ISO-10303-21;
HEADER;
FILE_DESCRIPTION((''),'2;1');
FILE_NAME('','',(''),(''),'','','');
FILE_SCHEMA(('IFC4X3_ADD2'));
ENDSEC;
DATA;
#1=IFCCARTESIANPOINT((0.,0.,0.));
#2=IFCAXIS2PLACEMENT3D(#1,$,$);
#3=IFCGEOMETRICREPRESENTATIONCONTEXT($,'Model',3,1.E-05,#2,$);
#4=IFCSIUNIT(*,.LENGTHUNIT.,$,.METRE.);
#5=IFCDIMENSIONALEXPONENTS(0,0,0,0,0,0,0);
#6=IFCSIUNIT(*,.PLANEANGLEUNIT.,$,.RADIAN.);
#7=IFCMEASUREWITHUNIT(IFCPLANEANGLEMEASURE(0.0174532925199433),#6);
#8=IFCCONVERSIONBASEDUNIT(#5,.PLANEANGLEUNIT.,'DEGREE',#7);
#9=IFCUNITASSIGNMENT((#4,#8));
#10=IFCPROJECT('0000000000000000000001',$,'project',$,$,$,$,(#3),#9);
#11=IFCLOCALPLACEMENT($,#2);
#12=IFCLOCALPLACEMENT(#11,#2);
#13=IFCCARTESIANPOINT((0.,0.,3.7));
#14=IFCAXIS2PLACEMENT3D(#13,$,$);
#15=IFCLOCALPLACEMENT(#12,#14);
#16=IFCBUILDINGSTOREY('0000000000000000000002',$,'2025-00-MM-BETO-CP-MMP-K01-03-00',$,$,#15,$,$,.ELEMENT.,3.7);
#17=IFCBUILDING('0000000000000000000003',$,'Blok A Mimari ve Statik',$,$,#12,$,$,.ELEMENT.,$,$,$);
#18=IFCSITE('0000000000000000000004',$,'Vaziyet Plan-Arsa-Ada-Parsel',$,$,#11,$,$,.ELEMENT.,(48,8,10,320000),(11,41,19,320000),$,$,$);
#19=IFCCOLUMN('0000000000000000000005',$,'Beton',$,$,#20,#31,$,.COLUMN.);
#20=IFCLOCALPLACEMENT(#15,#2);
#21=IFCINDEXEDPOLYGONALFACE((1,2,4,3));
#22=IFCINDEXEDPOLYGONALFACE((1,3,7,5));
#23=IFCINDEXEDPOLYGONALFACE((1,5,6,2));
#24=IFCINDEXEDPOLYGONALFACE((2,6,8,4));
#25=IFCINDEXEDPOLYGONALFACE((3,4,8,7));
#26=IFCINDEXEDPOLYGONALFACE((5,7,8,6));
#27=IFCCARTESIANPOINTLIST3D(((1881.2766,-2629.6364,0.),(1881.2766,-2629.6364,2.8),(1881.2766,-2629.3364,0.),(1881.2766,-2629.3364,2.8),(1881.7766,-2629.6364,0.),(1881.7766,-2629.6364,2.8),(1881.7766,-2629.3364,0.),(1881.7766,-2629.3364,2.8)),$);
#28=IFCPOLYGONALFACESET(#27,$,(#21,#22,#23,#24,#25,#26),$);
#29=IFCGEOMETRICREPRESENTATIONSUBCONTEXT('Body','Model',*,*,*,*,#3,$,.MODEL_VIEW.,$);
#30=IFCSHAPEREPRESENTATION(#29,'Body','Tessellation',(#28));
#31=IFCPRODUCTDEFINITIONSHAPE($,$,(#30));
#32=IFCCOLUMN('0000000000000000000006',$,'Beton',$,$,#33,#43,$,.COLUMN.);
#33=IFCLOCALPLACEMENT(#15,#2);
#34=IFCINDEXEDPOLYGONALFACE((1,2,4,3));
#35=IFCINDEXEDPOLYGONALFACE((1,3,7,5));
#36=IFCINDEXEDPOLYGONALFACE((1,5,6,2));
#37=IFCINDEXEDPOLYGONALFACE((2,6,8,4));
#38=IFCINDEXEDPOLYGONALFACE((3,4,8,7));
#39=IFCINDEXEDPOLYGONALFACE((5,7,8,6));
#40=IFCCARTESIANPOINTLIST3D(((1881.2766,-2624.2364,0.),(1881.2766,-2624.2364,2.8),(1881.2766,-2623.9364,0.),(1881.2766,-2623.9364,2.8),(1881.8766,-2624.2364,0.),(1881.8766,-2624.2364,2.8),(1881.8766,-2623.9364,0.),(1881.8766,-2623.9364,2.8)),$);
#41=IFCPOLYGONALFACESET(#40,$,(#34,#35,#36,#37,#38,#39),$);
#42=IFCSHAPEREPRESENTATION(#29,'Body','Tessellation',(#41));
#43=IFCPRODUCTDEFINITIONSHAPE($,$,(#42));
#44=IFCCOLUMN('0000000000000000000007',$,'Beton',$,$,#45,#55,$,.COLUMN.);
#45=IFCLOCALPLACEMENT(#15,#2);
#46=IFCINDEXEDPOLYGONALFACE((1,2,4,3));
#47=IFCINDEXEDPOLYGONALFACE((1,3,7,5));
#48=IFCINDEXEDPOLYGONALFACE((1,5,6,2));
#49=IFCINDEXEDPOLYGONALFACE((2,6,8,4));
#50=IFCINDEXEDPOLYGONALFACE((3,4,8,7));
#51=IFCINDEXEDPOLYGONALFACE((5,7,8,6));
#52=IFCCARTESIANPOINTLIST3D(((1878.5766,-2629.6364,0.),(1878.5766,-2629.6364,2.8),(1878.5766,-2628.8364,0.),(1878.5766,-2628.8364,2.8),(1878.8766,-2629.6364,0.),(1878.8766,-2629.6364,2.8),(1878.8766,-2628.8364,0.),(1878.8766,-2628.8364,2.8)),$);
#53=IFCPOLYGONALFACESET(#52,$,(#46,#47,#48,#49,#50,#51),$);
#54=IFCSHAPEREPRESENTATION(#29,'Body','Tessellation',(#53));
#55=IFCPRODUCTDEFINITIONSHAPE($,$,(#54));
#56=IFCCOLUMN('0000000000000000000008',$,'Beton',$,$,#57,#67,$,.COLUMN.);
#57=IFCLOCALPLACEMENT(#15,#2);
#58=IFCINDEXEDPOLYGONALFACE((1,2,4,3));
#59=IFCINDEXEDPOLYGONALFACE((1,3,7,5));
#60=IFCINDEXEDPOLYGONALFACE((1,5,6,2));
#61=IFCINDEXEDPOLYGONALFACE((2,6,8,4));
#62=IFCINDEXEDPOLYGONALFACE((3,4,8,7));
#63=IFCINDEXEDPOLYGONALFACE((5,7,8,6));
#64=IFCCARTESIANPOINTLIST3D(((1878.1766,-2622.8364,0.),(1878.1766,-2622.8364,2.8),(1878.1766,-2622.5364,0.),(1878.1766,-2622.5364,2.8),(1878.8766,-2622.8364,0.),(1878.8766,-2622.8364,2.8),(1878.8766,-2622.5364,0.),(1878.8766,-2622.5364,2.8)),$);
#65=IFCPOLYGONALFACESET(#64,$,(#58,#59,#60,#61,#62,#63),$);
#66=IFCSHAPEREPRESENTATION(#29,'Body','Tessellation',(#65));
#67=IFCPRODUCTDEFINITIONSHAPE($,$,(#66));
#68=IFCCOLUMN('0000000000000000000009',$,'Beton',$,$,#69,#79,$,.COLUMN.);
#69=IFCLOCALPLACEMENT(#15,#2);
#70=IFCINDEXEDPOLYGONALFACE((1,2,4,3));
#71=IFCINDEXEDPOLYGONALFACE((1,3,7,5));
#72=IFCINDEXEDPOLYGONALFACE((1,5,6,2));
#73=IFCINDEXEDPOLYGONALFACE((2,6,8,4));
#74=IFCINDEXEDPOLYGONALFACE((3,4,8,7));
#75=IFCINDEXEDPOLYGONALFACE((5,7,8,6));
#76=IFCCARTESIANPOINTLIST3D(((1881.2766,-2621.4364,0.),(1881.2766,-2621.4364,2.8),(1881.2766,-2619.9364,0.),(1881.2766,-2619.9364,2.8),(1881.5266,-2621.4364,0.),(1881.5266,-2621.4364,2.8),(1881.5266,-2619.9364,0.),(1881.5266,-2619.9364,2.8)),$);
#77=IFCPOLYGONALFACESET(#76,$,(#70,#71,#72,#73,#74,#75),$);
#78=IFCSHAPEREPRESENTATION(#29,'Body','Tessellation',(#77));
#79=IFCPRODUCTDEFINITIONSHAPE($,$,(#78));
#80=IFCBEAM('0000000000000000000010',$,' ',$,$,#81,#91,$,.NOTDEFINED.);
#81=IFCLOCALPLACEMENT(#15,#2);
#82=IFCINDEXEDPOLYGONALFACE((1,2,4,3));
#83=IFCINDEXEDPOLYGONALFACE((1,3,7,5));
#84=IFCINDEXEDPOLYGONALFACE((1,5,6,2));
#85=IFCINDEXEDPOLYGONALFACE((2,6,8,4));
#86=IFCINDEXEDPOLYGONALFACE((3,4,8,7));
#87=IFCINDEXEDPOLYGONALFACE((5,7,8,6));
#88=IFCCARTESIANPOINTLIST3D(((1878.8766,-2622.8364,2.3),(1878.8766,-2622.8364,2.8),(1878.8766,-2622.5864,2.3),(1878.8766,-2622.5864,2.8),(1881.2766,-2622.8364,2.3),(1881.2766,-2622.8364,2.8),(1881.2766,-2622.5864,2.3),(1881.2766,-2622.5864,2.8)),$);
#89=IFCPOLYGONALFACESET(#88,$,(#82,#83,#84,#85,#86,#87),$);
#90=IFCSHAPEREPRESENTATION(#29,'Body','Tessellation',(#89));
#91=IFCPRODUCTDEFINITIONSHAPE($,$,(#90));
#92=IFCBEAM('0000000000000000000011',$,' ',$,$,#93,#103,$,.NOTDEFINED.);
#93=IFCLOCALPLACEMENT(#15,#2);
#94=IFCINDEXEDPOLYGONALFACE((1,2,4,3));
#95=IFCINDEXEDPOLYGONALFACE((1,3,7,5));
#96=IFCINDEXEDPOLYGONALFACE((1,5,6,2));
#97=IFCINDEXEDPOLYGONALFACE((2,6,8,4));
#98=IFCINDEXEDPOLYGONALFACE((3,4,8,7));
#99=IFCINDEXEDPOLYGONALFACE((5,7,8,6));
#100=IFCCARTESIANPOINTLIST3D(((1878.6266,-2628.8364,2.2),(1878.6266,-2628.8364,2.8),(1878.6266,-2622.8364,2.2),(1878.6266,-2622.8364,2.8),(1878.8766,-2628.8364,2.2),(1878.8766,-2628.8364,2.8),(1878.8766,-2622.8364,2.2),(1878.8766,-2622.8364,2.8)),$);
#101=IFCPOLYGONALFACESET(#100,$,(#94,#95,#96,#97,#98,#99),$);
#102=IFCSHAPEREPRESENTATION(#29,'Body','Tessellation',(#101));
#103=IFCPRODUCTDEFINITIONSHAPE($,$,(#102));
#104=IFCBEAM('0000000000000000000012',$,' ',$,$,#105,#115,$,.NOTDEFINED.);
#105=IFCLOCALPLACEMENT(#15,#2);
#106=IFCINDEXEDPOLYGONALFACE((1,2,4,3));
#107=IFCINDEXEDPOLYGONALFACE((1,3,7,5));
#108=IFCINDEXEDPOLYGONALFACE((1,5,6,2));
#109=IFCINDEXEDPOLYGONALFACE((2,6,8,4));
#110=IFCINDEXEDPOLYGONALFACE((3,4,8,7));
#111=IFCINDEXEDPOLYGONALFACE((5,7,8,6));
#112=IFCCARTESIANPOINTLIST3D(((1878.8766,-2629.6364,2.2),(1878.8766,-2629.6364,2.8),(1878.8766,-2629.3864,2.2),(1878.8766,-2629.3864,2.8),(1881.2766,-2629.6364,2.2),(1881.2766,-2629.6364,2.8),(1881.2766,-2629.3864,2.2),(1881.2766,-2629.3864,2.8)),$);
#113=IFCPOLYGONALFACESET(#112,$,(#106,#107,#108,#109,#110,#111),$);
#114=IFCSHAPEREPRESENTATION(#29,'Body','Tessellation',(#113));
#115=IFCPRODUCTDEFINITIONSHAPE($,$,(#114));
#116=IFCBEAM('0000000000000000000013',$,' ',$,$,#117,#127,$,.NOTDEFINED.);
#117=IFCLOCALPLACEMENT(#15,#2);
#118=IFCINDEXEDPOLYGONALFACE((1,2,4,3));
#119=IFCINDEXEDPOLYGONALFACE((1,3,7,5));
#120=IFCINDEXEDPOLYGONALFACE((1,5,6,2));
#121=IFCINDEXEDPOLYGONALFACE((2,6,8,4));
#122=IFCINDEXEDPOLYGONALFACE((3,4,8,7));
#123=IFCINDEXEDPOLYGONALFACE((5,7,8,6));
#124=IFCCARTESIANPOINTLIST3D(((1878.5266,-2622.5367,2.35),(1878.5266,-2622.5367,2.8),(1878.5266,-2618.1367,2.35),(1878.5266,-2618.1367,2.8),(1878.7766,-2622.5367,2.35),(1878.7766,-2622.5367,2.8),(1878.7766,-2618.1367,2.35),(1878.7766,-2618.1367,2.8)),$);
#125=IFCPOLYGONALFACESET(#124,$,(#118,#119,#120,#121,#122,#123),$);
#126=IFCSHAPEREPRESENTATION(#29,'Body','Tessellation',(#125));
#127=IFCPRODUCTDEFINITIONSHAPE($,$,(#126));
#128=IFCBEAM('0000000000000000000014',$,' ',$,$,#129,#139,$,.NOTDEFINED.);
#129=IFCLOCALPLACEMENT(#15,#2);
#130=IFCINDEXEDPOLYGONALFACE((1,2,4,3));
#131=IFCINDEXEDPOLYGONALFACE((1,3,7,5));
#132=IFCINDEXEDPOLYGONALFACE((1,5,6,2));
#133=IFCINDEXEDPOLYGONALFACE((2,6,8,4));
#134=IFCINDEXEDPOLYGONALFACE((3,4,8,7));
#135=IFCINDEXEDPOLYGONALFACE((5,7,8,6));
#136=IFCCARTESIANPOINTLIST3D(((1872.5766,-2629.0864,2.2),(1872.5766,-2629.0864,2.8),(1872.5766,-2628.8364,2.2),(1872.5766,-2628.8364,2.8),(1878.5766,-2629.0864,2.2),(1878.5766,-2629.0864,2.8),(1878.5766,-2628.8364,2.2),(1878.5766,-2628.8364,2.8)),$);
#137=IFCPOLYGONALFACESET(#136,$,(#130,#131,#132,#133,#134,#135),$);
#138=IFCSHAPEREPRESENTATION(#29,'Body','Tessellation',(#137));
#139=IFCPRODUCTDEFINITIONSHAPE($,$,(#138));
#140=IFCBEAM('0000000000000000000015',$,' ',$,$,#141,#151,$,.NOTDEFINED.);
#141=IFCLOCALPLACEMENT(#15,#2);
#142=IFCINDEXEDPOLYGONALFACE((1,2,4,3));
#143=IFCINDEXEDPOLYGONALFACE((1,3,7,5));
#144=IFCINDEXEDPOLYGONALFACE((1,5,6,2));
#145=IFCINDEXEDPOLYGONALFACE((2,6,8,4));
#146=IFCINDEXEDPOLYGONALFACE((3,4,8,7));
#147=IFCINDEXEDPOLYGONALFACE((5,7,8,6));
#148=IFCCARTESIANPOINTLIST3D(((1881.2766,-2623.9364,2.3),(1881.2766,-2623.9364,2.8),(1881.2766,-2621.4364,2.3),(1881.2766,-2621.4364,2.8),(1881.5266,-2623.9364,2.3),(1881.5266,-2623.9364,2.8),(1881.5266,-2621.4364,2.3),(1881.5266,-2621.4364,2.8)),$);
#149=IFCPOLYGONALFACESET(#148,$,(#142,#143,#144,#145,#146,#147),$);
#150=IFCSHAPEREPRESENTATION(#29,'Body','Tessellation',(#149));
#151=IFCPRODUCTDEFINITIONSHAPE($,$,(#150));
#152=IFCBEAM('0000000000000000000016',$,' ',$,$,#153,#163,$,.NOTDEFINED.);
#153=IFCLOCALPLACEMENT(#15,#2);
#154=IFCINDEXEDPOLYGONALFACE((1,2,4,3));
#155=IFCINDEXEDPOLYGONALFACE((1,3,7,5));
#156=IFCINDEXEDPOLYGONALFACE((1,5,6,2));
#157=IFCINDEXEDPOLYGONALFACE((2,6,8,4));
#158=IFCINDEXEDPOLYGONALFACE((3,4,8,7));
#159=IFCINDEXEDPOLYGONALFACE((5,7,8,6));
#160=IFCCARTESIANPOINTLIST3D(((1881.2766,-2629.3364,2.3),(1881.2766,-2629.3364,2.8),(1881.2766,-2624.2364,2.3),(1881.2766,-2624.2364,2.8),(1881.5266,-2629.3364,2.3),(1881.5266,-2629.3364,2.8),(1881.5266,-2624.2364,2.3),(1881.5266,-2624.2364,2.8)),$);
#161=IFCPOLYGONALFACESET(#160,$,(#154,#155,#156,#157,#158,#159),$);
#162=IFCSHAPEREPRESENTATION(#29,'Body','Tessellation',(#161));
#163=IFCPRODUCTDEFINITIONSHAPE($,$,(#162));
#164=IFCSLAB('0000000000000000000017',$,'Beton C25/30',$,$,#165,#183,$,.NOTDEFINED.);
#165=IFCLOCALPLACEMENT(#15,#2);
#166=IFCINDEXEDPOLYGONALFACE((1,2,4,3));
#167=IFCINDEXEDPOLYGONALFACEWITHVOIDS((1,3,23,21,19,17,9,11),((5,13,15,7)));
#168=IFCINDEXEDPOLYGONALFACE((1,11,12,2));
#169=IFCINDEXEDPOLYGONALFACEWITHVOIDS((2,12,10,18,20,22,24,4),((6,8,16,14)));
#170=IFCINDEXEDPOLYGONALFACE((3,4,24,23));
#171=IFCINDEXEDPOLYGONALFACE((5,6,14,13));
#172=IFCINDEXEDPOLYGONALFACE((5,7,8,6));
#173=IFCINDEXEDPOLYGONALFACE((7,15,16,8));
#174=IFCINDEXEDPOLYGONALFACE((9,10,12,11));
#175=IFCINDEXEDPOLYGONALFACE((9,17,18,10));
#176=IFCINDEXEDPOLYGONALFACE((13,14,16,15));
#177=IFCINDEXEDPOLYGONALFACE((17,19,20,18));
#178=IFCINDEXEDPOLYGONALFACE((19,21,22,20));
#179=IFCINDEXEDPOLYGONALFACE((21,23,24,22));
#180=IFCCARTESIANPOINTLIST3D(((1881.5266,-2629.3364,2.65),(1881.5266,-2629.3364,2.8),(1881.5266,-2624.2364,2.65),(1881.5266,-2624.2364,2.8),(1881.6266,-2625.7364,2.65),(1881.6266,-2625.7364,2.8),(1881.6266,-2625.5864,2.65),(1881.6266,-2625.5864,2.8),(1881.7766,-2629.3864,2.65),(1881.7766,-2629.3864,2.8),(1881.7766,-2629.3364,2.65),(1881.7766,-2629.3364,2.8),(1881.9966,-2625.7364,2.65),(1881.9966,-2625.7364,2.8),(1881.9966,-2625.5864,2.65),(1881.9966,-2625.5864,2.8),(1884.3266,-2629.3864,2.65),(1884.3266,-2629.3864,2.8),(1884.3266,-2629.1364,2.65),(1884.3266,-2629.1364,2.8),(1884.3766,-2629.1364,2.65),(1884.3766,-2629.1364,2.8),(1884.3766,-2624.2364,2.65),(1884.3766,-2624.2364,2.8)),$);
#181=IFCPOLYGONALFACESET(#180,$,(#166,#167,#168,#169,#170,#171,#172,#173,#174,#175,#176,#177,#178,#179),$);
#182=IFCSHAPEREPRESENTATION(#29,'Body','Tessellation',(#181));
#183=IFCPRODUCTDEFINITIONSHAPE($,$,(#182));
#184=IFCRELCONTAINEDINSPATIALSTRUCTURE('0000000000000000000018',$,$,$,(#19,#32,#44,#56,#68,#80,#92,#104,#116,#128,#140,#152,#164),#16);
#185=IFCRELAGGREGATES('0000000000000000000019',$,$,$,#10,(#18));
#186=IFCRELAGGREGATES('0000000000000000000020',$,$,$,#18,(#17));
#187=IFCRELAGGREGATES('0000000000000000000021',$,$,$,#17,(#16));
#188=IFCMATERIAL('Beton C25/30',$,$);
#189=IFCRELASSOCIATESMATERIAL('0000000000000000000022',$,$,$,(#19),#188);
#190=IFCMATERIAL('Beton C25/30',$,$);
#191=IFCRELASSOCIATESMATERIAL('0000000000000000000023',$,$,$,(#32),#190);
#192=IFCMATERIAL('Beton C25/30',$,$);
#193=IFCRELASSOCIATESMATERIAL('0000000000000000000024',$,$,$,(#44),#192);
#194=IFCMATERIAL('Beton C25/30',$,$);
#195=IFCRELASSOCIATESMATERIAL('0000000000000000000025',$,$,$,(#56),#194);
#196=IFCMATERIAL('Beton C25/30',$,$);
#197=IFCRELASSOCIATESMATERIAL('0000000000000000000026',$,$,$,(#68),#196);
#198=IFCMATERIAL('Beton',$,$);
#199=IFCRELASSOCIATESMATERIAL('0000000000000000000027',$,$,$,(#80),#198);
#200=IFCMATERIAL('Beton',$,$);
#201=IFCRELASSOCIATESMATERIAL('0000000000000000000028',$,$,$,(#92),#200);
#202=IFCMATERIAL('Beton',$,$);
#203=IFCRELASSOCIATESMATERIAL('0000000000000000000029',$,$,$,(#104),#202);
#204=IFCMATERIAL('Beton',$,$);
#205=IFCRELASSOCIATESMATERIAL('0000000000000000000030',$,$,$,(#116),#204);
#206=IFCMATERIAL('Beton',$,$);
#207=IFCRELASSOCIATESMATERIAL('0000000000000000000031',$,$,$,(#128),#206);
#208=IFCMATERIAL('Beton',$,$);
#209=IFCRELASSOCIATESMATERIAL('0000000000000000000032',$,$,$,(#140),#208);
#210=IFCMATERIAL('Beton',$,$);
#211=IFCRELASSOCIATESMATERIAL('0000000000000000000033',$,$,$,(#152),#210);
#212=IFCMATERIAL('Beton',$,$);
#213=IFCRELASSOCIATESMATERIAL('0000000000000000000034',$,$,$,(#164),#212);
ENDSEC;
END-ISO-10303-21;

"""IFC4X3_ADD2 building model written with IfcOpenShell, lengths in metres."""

from ifc_helpers import new_model, entity, si_unit, converted_unit, frame, frame_2d, origin, origin_with_axes, place, context, subcontext, project, spatial, polyline, rectangle, outline, extrude, material, element, save


model = new_model("IFC4X3_ADD2")

# Units and contexts
model_context = context("Model", 3, precision=1e-05, world=origin())
body_context = subcontext(model_context, "Body", "Model", "MODEL_VIEW")
ifc_project = project(units=[si_unit("LENGTHUNIT", "METRE"), converted_unit("PLANEANGLEUNIT", "DEGREE", entity("IfcPlaneAngleMeasure", 0.0174532925199433), si_unit("PLANEANGLEUNIT", "RADIAN"), dimensions=[0, 0, 0, 0, 0, 0, 0])], contexts=[model_context])

# Site, building, storey
site_placement = place(None, origin())
site = spatial("IfcSite", under=ifc_project, at=site_placement, Name="Vaziyet Plan-Arsa-Ada-Parsel", CompositionType="ELEMENT", RefLatitude=(48, 8, 10, 320000), RefLongitude=(11, 41, 19, 320000))
building_placement = place(site_placement, origin())
building = spatial("IfcBuilding", under=site, at=building_placement, Name="Blok A Mimari ve Statik", CompositionType="ELEMENT")
storey_placement = place(building_placement, frame((0.0, 0.0, 3.7)))
storey = spatial("IfcBuildingStorey", under=building, at=storey_placement, Name="2025-00-MM-BETO-CP-MMP-K01-03-00", CompositionType="ELEMENT", Elevation=3.7)

# Columns
ifc_material_1 = material(Name="Beton C25/30")
column_1_placement = place(storey_placement, frame((1881.2766, -2629.6364, 0.0)))
element("IfcColumn", 1, at=column_1_placement, inside=storey, material=ifc_material_1, Name="Beton", PredefinedType="COLUMN", context=body_context, shape_type="SweptSolid", body=[
    extrude(outline(polyline([(0.0, 0.3), (0.0, 0.0), (0.5, 0.0), (0.5, 0.3), (0.0, 0.3)])), origin_with_axes(), (0.0, 0.0, 1.0), 2.8),
])
ifc_material_2 = material(Name="Beton C25/30")
column_2_placement = place(storey_placement, frame((1881.2766, -2624.2364, 0.0)))
element("IfcColumn", 2, at=column_2_placement, inside=storey, material=ifc_material_2, Name="Beton", PredefinedType="COLUMN", context=body_context, shape_type="SweptSolid", body=[
    extrude(outline(polyline([(0.0, 0.0), (0.6, 0.0), (0.6, 0.3), (0.0, 0.3), (0.0, 0.0)])), origin_with_axes(), (0.0, 0.0, 1.0), 2.8),
])
ifc_material_3 = material(Name="Beton C25/30")
column_3_placement = place(storey_placement, frame((1878.5766, -2629.6364, 0.0)))
element("IfcColumn", 3, at=column_3_placement, inside=storey, material=ifc_material_3, Name="Beton", PredefinedType="COLUMN", context=body_context, shape_type="SweptSolid", body=[
    extrude(outline(polyline([(0.0, 0.0), (0.3, 0.0), (0.3, 0.8), (0.0, 0.8), (0.0, 0.0)])), origin_with_axes(), (0.0, 0.0, 1.0), 2.8),
])
ifc_material_4 = material(Name="Beton C25/30")
column_4_placement = place(storey_placement, frame((1878.1766, -2622.8364, 0.0)))
element("IfcColumn", 4, at=column_4_placement, inside=storey, material=ifc_material_4, Name="Beton", PredefinedType="COLUMN", context=body_context, shape_type="SweptSolid", body=[
    extrude(outline(polyline([(0.0, 0.0), (0.7, 0.0), (0.7, 0.3), (0.0, 0.3), (0.0, 0.0)])), origin_with_axes(), (0.0, 0.0, 1.0), 2.8),
])
ifc_material_5 = material(Name="Beton C25/30")
column_5_placement = place(storey_placement, frame((1881.2766, -2621.4364, 0.0)))
element("IfcColumn", 5, at=column_5_placement, inside=storey, material=ifc_material_5, Name="Beton", PredefinedType="COLUMN", context=body_context, shape_type="SweptSolid", body=[
    extrude(outline(polyline([(0.0, 0.0), (0.25, 0.0), (0.25, 1.5), (0.0, 1.5), (0.0, 0.0)])), origin_with_axes(), (0.0, 0.0, 1.0), 2.8),
])

# Beams
ifc_material_6 = material(Name="Beton")
beam_1_placement = place(storey_placement, frame((1878.8766, -2622.8364, 2.3)))
element("IfcBeam", 6, at=beam_1_placement, inside=storey, material=ifc_material_6, Name=" ", PredefinedType="NOTDEFINED", context=body_context, shape_type="SweptSolid", body=[
    extrude(rectangle(XDim=0.25, YDim=0.5, at=frame_2d((0.125, 0.25), x_axis=(1.0, 0.0))), frame((0.0, 0.0, 0.0), z_axis=(1.0, 0.0, 0.0), x_axis=(0.0, 1.0, 0.0)), (0.0, 0.0, 1.0), 2.4),
])
ifc_material_7 = material(Name="Beton")
beam_2_placement = place(storey_placement, frame((1878.8766, -2628.8364, 2.2), z_axis=(0.0, 0.0, 1.0), x_axis=(0.0, 1.0, 0.0)))
element("IfcBeam", 7, at=beam_2_placement, inside=storey, material=ifc_material_7, Name=" ", PredefinedType="NOTDEFINED", context=body_context, shape_type="SweptSolid", body=[
    extrude(rectangle(XDim=0.25, YDim=0.6, at=frame_2d((0.125, 0.3), x_axis=(1.0, 0.0))), frame((0.0, 0.0, 0.0), z_axis=(1.0, 0.0, 0.0), x_axis=(0.0, 1.0, 0.0)), (0.0, 0.0, 1.0), 6.0),
])
ifc_material_8 = material(Name="Beton")
beam_3_placement = place(storey_placement, frame((1878.8766, -2629.6364, 2.2)))
element("IfcBeam", 8, at=beam_3_placement, inside=storey, material=ifc_material_8, Name=" ", PredefinedType="NOTDEFINED", context=body_context, shape_type="SweptSolid", body=[
    extrude(rectangle(XDim=0.25, YDim=0.6, at=frame_2d((0.125, 0.3), x_axis=(1.0, 0.0))), frame((0.0, 0.0, 0.0), z_axis=(1.0, 0.0, 0.0), x_axis=(0.0, 1.0, 0.0)), (0.0, 0.0, 1.0), 2.4),
])
ifc_material_9 = material(Name="Beton")
beam_4_placement = place(storey_placement, frame((1878.7766, -2622.5367, 2.35), z_axis=(0.0, 0.0, 1.0), x_axis=(0.0, 1.0, 0.0)))
element("IfcBeam", 9, at=beam_4_placement, inside=storey, material=ifc_material_9, Name=" ", PredefinedType="NOTDEFINED", context=body_context, shape_type="SweptSolid", body=[
    extrude(rectangle(XDim=0.25, YDim=0.45, at=frame_2d((0.125, 0.225), x_axis=(1.0, 0.0))), frame((0.0, 0.0, 0.0), z_axis=(1.0, 0.0, 0.0), x_axis=(0.0, 1.0, 0.0)), (0.0, 0.0, 1.0), 4.4),
])
ifc_material_10 = material(Name="Beton")
beam_5_placement = place(storey_placement, frame((1878.5766, -2628.8364, 2.2), z_axis=(0.0, 0.0, 1.0), x_axis=(-1.0, 0.0, 0.0)))
element("IfcBeam", 10, at=beam_5_placement, inside=storey, material=ifc_material_10, Name=" ", PredefinedType="NOTDEFINED", context=body_context, shape_type="SweptSolid", body=[
    extrude(rectangle(XDim=0.25, YDim=0.6, at=frame_2d((0.125, 0.3), x_axis=(1.0, 0.0))), frame((0.0, 0.0, 0.0), z_axis=(1.0, 0.0, 0.0), x_axis=(0.0, 1.0, 0.0)), (0.0, 0.0, 1.0), 6.0),
])
ifc_material_11 = material(Name="Beton")
beam_6_placement = place(storey_placement, frame((1881.2766, -2621.4364, 2.3), z_axis=(0.0, 0.0, 1.0), x_axis=(0.0, -1.0, 0.0)))
element("IfcBeam", 11, at=beam_6_placement, inside=storey, material=ifc_material_11, Name=" ", PredefinedType="NOTDEFINED", context=body_context, shape_type="SweptSolid", body=[
    extrude(rectangle(XDim=0.25, YDim=0.5, at=frame_2d((0.125, 0.25), x_axis=(1.0, 0.0))), frame((0.0, 0.0, 0.0), z_axis=(1.0, 0.0, 0.0), x_axis=(0.0, 1.0, 0.0)), (0.0, 0.0, 1.0), 2.5),
])
ifc_material_12 = material(Name="Beton")
beam_7_placement = place(storey_placement, frame((1881.2766, -2624.2364, 2.3), z_axis=(0.0, 0.0, 1.0), x_axis=(0.0, -1.0, 0.0)))
element("IfcBeam", 12, at=beam_7_placement, inside=storey, material=ifc_material_12, Name=" ", PredefinedType="NOTDEFINED", context=body_context, shape_type="SweptSolid", body=[
    extrude(rectangle(XDim=0.25, YDim=0.5, at=frame_2d((0.125, 0.25), x_axis=(1.0, 0.0))), frame((0.0, 0.0, 0.0), z_axis=(1.0, 0.0, 0.0), x_axis=(0.0, 1.0, 0.0)), (0.0, 0.0, 1.0), 5.1),
])

# Slab
ifc_material_13 = material(Name="Beton")
slab_1_placement = place(storey_placement, frame((1881.5266, -2629.3864, 2.65)))
element("IfcSlab", 13, at=slab_1_placement, inside=storey, material=ifc_material_13, Name="Beton C25/30", PredefinedType="NOTDEFINED", context=body_context, shape_type="SweptSolid", body=[
    extrude(outline(polyline([(0.0, 5.15), (0.0, 0.05), (0.25, 0.05), (0.25, 0.0), (2.8, 0.0), (2.8, 0.25), (2.85, 0.25), (2.85, 5.15), (0.0, 5.15)]), holes=[polyline([(0.1, 3.8), (0.47, 3.8), (0.47, 3.65), (0.1, 3.65), (0.1, 3.8)])]), origin_with_axes(), (0.0, 0.0, 1.0), 0.15),
])

save(model, "model.ifc")
